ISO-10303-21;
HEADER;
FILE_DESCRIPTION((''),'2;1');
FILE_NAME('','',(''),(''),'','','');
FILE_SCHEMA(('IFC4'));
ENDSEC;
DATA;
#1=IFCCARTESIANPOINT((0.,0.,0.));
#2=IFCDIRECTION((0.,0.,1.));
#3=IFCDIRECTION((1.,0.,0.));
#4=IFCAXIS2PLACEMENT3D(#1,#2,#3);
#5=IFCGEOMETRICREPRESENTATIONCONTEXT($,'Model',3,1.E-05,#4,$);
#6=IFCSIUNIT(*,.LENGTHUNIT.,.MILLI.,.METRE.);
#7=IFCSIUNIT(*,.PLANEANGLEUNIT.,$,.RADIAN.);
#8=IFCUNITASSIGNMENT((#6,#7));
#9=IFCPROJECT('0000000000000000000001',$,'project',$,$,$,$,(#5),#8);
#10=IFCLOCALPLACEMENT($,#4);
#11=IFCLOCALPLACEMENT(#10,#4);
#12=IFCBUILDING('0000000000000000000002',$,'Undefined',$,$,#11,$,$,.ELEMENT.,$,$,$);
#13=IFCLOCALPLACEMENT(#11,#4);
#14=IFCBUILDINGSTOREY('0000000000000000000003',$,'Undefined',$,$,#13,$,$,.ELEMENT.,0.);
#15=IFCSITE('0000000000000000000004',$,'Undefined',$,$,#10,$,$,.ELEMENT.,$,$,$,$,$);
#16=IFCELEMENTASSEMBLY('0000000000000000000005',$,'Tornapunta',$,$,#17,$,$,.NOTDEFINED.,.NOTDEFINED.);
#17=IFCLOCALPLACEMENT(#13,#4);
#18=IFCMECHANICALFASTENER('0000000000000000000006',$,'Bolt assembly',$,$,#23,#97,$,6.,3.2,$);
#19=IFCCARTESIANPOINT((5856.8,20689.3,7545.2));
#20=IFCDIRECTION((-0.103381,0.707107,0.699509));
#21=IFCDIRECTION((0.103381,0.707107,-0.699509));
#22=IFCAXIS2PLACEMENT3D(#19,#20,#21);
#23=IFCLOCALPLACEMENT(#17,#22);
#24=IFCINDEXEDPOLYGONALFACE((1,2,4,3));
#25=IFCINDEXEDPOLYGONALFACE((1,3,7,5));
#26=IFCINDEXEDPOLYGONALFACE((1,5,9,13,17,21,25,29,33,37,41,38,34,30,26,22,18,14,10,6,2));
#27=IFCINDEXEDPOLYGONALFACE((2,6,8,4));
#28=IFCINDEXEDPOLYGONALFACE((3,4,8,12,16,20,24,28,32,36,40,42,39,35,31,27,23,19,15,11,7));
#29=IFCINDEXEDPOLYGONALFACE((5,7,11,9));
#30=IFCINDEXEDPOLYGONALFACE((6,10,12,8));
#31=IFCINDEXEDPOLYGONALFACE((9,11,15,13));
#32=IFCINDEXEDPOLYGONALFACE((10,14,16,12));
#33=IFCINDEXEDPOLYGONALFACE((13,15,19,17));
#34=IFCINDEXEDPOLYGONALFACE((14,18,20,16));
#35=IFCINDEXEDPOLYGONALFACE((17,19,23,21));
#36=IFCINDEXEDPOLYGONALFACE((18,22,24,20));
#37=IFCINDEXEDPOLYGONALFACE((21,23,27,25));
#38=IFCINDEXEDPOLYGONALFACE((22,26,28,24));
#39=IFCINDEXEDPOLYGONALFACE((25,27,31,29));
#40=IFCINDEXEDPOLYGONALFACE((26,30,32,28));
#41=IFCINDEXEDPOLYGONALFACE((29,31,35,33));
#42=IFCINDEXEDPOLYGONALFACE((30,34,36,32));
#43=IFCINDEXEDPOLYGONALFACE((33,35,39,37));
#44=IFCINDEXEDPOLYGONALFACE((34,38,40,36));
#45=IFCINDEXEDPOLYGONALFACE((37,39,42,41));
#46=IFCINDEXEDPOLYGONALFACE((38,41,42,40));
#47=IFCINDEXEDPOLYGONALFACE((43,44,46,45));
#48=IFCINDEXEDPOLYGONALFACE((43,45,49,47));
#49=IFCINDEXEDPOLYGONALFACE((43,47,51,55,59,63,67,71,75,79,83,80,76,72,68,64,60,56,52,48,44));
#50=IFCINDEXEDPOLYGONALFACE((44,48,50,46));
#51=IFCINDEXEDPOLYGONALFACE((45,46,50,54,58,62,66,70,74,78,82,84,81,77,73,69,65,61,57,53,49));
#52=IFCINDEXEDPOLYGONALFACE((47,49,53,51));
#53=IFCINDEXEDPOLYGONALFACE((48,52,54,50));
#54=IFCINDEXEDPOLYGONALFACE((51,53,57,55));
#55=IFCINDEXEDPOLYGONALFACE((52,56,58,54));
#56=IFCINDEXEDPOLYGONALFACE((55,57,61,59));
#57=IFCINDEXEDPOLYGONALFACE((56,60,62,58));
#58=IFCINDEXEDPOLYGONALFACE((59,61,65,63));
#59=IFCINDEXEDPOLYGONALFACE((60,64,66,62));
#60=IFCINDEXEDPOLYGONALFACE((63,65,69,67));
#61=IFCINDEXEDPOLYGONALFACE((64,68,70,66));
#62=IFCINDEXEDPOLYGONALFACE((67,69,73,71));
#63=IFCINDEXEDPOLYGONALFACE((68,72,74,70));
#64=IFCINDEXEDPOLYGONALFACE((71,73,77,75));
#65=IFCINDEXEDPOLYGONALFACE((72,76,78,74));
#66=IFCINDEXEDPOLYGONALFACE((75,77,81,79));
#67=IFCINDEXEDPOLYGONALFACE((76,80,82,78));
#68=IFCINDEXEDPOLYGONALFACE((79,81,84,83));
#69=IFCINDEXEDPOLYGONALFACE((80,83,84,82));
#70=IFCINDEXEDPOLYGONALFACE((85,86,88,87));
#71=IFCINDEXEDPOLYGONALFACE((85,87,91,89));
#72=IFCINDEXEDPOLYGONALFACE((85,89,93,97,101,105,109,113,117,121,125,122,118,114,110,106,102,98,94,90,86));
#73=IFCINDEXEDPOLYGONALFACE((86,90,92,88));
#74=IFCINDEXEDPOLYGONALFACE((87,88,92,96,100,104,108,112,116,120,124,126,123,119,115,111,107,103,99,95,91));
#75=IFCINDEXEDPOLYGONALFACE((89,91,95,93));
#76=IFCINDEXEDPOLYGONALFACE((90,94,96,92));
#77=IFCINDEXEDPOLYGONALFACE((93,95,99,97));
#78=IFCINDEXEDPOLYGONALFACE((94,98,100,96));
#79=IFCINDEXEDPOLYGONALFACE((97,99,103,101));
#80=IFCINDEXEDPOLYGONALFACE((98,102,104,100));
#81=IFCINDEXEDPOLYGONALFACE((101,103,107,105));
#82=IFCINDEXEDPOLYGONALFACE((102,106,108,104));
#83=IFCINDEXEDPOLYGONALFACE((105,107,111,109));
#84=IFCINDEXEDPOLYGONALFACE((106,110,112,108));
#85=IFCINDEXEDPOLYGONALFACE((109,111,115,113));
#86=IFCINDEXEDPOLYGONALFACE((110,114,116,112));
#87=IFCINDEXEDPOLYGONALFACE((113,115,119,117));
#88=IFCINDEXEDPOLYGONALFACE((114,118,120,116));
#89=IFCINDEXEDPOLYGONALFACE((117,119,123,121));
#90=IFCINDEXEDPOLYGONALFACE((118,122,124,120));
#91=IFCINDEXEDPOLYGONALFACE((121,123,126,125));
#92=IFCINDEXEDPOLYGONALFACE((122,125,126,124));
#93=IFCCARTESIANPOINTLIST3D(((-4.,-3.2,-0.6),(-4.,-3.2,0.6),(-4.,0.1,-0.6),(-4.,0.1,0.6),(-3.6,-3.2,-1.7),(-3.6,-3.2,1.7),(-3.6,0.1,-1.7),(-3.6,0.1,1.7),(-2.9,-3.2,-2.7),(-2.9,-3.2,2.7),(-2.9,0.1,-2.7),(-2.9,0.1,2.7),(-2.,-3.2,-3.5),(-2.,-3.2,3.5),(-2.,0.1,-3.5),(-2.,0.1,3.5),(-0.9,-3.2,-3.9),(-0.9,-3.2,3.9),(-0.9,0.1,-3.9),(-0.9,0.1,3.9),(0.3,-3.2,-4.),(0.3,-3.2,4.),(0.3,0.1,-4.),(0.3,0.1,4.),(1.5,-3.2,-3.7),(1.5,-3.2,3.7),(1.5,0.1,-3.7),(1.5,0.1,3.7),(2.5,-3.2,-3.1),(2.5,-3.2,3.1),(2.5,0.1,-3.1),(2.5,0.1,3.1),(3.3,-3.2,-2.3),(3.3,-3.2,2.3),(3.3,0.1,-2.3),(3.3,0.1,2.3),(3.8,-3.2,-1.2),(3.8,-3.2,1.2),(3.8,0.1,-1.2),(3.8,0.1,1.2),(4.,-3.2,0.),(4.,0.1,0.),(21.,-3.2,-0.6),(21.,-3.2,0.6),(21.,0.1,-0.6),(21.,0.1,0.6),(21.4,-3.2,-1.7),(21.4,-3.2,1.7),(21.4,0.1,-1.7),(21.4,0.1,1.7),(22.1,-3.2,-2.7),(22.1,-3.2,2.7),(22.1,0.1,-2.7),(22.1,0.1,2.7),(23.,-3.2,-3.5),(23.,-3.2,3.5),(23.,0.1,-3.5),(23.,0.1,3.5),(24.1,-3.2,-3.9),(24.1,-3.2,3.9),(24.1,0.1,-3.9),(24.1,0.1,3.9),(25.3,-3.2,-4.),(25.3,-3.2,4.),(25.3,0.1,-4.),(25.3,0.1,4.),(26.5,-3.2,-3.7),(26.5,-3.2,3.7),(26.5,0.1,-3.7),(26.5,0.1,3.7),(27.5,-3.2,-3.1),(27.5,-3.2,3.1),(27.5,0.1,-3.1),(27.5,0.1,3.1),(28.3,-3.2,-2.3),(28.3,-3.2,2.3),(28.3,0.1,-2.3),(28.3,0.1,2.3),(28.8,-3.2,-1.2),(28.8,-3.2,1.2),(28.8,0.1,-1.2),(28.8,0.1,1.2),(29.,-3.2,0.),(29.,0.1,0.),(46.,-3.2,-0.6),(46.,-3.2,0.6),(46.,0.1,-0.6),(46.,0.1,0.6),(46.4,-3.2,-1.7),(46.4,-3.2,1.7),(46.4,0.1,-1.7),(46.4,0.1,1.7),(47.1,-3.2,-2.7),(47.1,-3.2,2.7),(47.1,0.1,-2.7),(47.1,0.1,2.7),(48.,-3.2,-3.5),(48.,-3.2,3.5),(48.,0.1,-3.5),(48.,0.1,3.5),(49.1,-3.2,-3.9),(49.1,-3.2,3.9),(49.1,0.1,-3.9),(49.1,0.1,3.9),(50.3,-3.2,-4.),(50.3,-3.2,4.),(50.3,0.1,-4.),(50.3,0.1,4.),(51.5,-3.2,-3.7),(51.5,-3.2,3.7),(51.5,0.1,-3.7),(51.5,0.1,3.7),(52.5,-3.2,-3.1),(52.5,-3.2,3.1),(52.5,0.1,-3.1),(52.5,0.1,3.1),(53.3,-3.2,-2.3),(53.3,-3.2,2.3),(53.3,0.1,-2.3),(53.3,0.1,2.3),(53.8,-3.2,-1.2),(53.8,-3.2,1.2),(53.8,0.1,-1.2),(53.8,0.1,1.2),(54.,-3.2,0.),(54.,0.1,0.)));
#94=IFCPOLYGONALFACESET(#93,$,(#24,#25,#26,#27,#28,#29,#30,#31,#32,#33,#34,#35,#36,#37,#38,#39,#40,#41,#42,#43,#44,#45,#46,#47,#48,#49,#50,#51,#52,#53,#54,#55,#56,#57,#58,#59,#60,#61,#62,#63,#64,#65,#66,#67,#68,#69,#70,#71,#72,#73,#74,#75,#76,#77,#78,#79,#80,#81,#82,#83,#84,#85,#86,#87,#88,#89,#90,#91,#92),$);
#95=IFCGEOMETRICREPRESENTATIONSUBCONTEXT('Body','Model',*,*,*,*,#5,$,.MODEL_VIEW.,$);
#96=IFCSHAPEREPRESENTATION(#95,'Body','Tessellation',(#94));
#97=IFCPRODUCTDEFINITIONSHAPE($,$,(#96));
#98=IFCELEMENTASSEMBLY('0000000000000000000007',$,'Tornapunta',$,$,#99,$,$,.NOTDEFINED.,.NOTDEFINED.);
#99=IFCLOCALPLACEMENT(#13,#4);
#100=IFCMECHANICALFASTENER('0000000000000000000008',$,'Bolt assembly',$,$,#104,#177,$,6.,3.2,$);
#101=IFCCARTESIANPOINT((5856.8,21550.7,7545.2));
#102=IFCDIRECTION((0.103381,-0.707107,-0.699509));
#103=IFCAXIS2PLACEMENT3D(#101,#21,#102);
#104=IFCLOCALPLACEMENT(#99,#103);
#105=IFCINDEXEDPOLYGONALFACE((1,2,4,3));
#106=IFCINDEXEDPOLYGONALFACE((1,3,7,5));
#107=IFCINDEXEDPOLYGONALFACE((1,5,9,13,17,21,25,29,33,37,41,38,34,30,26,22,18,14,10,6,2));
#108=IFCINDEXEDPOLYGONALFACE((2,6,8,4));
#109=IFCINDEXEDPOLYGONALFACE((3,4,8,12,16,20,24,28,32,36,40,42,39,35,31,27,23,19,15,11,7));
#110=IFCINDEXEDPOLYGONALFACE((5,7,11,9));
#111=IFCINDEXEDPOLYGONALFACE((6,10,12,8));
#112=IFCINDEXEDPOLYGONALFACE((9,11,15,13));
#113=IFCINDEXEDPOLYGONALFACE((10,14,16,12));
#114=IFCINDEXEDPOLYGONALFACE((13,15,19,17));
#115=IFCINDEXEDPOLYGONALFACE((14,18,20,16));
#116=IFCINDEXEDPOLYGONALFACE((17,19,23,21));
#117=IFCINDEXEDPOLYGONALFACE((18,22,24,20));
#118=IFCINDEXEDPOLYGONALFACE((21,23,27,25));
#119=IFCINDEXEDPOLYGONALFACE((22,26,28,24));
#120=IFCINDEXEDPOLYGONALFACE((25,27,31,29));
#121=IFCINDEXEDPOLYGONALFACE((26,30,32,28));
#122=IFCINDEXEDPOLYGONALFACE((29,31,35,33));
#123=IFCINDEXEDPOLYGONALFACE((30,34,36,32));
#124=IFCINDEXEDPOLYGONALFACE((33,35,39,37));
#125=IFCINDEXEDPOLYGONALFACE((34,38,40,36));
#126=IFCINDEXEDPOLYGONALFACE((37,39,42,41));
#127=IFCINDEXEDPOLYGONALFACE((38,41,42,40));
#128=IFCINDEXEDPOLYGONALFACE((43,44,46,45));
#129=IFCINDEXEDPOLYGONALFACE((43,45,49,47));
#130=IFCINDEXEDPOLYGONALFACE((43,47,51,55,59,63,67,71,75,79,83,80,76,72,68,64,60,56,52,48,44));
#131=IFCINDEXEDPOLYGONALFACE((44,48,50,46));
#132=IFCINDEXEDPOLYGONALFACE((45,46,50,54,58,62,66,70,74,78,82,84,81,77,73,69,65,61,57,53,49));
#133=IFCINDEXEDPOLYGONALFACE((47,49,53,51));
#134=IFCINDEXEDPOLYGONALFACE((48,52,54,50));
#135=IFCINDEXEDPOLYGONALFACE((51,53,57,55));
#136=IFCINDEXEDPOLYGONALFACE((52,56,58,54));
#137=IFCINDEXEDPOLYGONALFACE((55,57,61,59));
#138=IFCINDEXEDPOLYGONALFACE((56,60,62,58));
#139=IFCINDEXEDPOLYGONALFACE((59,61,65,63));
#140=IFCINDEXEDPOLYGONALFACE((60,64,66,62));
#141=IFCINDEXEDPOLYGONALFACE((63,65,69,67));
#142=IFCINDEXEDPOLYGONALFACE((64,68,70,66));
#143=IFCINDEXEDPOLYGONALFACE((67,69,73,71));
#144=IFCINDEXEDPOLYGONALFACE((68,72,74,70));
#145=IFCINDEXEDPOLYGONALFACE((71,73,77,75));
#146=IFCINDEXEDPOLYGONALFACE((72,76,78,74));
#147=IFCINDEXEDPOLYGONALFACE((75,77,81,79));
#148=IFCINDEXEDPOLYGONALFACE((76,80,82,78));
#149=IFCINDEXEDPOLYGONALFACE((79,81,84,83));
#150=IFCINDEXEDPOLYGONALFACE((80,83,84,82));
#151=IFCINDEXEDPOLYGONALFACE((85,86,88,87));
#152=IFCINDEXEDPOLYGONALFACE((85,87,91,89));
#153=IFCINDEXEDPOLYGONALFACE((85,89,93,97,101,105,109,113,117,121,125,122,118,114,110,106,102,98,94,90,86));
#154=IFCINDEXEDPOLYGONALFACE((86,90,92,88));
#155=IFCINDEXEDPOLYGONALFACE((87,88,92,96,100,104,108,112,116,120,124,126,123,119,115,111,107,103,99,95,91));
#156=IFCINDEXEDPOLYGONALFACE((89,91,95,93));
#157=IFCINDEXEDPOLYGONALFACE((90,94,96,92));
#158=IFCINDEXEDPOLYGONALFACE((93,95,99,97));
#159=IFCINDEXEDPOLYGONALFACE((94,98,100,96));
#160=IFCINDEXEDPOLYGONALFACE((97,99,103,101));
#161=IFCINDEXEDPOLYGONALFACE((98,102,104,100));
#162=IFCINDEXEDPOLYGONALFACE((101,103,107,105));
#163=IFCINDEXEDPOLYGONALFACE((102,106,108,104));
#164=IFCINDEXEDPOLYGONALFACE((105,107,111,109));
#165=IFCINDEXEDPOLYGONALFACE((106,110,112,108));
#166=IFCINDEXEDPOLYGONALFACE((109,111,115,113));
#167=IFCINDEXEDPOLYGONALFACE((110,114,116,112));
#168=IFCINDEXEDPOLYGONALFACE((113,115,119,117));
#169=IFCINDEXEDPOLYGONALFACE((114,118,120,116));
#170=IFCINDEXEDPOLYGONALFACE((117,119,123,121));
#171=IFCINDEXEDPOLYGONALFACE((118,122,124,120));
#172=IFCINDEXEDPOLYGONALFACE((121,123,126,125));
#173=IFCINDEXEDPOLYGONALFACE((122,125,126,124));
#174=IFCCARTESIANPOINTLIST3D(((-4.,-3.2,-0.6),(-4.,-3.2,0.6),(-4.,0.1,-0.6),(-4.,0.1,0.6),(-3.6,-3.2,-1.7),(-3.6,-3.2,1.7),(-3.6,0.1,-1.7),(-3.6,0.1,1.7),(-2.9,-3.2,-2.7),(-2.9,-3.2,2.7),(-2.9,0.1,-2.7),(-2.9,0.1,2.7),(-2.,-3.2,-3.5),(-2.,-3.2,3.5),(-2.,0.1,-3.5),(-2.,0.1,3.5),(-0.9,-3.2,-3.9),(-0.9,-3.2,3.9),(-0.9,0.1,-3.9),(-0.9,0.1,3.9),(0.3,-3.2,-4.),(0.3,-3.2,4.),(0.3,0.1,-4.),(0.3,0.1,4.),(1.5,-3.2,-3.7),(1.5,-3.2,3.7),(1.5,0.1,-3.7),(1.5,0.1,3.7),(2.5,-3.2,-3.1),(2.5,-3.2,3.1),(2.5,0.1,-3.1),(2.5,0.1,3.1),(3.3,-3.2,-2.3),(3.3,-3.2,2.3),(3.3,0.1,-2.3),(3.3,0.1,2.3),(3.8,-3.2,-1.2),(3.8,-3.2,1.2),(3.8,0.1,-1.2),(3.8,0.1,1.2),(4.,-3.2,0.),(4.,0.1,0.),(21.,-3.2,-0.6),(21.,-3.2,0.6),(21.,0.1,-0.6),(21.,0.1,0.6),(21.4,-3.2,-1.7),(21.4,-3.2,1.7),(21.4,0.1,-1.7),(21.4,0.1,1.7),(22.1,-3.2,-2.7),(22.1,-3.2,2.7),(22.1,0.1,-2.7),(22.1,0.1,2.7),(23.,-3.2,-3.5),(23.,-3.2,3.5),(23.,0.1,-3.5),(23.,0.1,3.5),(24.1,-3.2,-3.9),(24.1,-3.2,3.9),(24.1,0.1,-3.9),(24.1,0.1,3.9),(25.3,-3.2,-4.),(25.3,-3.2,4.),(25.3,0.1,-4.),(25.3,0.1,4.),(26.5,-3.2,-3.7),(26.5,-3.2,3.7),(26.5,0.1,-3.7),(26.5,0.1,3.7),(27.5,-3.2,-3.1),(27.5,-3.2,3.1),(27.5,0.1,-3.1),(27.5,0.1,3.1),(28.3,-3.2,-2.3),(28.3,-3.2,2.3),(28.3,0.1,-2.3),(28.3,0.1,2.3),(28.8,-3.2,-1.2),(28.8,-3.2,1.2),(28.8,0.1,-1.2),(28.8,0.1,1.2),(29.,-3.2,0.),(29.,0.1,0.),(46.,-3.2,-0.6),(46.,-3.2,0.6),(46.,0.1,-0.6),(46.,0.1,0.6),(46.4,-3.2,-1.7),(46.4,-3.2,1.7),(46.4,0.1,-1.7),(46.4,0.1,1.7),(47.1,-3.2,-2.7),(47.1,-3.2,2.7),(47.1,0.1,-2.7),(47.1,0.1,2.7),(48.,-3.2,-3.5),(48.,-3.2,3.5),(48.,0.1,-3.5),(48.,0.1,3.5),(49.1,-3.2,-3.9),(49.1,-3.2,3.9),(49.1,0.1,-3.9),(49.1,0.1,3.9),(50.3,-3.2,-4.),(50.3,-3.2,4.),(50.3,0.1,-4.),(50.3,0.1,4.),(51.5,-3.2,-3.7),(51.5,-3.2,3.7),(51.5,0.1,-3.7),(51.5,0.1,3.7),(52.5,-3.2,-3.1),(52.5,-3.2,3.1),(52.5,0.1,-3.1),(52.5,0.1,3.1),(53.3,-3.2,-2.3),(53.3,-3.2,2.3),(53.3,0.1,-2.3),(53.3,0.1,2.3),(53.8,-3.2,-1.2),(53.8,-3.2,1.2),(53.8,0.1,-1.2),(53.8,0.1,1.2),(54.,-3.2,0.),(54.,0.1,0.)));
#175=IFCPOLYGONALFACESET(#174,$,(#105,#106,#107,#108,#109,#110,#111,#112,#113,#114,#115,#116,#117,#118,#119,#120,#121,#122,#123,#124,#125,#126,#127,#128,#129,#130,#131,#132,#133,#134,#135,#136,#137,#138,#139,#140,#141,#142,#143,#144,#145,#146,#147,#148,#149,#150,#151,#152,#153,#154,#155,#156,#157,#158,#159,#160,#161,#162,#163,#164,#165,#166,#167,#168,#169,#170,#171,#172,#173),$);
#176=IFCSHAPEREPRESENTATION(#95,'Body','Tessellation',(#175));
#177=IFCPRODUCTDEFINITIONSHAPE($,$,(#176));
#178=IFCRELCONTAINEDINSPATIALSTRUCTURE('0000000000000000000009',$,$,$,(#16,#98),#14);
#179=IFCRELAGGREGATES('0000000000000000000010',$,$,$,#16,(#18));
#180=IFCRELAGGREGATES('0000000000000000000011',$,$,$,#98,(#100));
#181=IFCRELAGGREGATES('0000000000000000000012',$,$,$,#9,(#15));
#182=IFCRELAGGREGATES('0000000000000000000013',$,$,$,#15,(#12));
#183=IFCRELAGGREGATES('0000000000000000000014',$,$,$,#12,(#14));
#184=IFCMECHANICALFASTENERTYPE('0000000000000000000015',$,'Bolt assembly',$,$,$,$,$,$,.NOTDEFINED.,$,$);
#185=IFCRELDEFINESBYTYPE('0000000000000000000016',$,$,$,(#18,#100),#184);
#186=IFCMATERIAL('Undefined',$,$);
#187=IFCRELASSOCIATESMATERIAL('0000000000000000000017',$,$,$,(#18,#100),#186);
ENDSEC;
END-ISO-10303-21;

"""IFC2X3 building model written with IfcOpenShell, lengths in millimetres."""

from ifc_helpers import new_model, si_unit, frame, origin_with_axes, origin_2d_with_axis, place, context, subcontext, project, spatial, circle, extrude, source, transform, mapped, material, type_object, element, aggregate, save


model = new_model("IFC2X3")

# Units and contexts
model_context = context("Model", 3, precision=1e-05, world=origin_with_axes())
body_context = subcontext(model_context, "Body", "Model", "MODEL_VIEW")
ifc_project = project(units=[si_unit("LENGTHUNIT", "METRE", prefix="MILLI"), si_unit("PLANEANGLEUNIT", "RADIAN")], contexts=[model_context])

# Site, building, storey
site_placement = place(None, origin_with_axes())
site = spatial("IfcSite", under=ifc_project, at=site_placement, Name="Undefined", CompositionType="ELEMENT")
building_placement = place(site_placement, origin_with_axes())
building = spatial("IfcBuilding", under=site, at=building_placement, Name="Undefined", CompositionType="ELEMENT")
storey_placement = place(building_placement, origin_with_axes())
storey = spatial("IfcBuildingStorey", under=building, at=storey_placement, Name="Undefined", CompositionType="ELEMENT", Elevation=0.0)

# Shared definitions
ifc_material_1 = material(Name="Undefined")
mechanical_fastener_type = type_object("IfcMechanicalFastenerType", Name="Bolt assembly")

# Element assemblies, mechanical fasteners
assembly_1_placement = place(storey_placement, origin_with_axes())
assembly_1 = element("IfcElementAssembly", 1, at=assembly_1_placement, inside=storey, Name="Tornapunta", AssemblyPlace="NOTDEFINED", PredefinedType="NOTDEFINED")
shared_shape_1 = source(origin_with_axes(), body_context, "Body", "SweptSolid", [
    extrude(circle(Radius=4.0, at=origin_2d_with_axis()), frame((0.0, -3.2, 0.0), z_axis=(0.0, 1.0, 0.0), x_axis=(1.0, 0.0, 0.0)), (0.0, 0.0, 1.0), 3.3),
])
mechanical_fastener_1_placement = place(assembly_1_placement, frame((5856.8, 20689.3, 7545.2), z_axis=(-0.103381, 0.707107, 0.699509), x_axis=(0.103381, 0.707107, -0.699509)))
mechanical_fastener_1 = element("IfcMechanicalFastener", 2, at=mechanical_fastener_1_placement, type_object=mechanical_fastener_type, material=ifc_material_1, Name="Bolt assembly", NominalDiameter=6.0, NominalLength=3.2, context=body_context, shape_type="MappedRepresentation", body=[
    mapped(shared_shape_1, transform((0.0, 0.0, 0.0))),
    mapped(shared_shape_1, transform((25.0, 0.0, 0.0))),
    mapped(shared_shape_1, transform((50.0, 0.0, 0.0))),
])
aggregate(assembly_1, [mechanical_fastener_1])
assembly_2_placement = place(storey_placement, origin_with_axes())
assembly_2 = element("IfcElementAssembly", 3, at=assembly_2_placement, inside=storey, Name="Tornapunta", AssemblyPlace="NOTDEFINED", PredefinedType="NOTDEFINED")
mechanical_fastener_2_placement = place(assembly_2_placement, frame((5856.8, 21550.7, 7545.2), z_axis=(0.103381, 0.707107, -0.699509), x_axis=(0.103381, -0.707107, -0.699509)))
mechanical_fastener_2 = element("IfcMechanicalFastener", 4, at=mechanical_fastener_2_placement, type_object=mechanical_fastener_type, material=ifc_material_1, Name="Bolt assembly", NominalDiameter=6.0, NominalLength=3.2, context=body_context, shape_type="MappedRepresentation", body=[
    mapped(shared_shape_1, transform((0.0, 0.0, 0.0))),
    mapped(shared_shape_1, transform((25.0, 0.0, 0.0))),
    mapped(shared_shape_1, transform((50.0, 0.0, 0.0))),
])
aggregate(assembly_2, [mechanical_fastener_2])

save(model, "model.ifc")
